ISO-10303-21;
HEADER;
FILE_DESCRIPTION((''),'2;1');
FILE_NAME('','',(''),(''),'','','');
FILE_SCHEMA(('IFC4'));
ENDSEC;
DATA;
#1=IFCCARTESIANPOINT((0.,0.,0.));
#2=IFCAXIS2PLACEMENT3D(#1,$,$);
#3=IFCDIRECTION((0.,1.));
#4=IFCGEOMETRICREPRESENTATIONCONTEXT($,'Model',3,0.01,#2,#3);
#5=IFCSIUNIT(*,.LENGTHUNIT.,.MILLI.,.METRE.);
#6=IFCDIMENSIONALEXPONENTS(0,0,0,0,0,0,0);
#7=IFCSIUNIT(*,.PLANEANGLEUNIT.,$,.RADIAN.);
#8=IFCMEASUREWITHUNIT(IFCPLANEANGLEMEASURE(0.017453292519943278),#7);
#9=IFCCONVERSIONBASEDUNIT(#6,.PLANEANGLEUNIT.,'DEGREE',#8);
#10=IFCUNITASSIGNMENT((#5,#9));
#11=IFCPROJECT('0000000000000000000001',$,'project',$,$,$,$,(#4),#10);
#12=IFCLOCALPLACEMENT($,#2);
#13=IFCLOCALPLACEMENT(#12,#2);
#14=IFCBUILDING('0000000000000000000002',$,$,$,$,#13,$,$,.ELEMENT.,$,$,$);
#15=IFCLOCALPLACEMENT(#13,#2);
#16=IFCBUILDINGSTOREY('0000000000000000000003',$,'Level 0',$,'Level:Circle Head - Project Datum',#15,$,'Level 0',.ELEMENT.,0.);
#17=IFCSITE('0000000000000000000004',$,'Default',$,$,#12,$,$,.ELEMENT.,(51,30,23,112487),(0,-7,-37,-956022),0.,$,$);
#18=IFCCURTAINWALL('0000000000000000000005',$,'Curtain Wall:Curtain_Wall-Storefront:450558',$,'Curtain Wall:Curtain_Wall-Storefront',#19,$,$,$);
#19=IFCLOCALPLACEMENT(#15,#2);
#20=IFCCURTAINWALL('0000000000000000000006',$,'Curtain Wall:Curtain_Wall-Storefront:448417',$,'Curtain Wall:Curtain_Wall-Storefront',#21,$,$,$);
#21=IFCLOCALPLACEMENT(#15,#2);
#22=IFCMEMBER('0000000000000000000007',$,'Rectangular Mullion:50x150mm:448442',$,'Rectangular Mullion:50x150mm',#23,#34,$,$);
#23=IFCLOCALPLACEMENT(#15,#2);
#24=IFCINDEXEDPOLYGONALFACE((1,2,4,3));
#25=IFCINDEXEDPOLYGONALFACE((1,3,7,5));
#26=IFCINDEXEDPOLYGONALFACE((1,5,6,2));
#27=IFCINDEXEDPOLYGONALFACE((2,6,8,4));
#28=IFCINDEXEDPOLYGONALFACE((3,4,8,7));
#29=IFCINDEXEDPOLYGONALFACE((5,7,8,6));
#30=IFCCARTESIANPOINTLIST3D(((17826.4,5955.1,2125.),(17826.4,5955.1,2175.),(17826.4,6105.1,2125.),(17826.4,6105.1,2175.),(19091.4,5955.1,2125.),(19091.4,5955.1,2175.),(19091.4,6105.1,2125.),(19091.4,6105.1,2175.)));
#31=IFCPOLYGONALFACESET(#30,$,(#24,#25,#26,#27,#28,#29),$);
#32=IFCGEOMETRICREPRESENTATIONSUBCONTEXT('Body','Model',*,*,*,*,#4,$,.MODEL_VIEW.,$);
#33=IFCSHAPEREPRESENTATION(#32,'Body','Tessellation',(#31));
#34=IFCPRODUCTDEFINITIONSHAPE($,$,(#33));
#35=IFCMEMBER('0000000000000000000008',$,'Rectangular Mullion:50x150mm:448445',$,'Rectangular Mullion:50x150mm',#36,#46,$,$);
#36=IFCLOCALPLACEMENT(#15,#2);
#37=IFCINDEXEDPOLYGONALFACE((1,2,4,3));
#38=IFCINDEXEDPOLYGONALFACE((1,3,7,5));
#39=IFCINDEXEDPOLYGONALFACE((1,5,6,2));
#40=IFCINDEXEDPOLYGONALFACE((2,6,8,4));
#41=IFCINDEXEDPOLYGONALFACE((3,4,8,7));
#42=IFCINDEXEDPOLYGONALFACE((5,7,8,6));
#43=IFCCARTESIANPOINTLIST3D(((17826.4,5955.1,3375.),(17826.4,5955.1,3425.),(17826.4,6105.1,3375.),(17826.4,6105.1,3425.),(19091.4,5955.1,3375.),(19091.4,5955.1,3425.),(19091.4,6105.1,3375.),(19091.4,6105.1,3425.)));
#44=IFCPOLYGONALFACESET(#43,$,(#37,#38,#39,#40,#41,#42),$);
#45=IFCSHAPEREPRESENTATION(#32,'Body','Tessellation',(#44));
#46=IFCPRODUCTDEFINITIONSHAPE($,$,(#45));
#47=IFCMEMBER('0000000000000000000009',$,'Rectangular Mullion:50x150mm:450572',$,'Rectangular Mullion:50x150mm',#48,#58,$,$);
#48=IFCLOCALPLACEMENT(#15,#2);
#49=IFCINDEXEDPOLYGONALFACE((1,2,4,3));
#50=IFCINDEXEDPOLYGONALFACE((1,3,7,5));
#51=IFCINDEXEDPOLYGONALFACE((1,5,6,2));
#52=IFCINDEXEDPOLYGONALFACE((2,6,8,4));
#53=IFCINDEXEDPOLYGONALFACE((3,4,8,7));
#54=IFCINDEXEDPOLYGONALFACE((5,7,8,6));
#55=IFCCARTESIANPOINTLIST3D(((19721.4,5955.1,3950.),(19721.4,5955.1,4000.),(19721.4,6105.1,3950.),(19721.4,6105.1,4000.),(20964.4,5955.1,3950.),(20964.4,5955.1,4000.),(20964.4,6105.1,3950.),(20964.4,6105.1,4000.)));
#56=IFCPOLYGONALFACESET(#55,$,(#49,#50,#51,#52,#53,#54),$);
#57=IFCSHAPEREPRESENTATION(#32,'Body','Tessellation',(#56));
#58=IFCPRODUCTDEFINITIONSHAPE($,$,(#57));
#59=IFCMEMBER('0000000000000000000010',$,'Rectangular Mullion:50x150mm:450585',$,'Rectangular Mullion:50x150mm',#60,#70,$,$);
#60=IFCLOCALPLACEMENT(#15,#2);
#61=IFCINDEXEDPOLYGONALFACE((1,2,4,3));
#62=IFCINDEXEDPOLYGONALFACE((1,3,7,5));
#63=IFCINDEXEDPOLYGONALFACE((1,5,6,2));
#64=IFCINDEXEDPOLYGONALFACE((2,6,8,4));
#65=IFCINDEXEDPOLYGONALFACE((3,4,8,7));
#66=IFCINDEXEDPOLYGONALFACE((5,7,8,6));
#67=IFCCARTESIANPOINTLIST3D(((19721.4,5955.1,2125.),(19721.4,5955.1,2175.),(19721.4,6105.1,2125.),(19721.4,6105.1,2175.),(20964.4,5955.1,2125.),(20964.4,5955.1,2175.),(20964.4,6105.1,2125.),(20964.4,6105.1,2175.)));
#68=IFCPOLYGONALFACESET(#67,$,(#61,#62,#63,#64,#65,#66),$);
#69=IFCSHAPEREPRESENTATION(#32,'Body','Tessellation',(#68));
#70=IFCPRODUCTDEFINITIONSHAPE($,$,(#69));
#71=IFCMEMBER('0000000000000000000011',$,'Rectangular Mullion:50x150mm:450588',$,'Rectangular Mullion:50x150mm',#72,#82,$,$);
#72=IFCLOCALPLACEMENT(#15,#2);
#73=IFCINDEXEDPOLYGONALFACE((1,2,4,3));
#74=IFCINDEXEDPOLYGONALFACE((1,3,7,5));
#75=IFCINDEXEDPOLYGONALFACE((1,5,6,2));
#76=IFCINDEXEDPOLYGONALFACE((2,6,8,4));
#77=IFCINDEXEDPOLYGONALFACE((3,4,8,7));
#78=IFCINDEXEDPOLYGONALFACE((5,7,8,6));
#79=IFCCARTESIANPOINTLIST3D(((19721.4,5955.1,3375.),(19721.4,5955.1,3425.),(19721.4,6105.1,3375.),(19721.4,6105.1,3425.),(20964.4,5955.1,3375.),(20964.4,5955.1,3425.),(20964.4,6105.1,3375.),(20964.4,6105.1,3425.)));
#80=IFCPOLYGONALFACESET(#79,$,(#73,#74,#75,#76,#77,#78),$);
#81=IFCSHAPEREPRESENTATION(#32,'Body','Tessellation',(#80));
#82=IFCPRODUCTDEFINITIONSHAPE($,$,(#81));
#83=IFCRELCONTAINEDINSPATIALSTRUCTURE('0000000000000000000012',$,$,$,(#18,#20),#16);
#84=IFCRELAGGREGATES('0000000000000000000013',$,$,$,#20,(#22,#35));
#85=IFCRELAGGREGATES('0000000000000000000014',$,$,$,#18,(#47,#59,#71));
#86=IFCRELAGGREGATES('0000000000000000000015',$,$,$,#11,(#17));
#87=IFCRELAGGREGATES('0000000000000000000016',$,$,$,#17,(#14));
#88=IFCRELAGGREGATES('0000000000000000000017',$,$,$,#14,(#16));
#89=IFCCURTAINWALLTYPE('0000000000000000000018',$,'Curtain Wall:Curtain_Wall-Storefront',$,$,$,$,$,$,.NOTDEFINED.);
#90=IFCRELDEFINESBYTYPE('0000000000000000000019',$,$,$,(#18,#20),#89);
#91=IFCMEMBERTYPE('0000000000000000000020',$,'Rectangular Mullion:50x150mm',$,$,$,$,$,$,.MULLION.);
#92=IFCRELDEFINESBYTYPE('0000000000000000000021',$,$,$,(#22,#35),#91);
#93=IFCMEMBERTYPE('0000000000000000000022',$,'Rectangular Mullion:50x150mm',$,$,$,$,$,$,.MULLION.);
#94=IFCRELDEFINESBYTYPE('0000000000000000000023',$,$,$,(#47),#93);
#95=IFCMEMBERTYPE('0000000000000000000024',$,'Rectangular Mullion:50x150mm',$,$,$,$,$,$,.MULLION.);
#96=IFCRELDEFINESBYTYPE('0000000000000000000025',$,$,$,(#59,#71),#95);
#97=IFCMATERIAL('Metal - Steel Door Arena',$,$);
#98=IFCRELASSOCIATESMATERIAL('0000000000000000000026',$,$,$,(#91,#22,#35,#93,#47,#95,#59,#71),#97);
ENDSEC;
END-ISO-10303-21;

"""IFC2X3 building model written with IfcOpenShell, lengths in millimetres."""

from ifc_helpers import new_model, entity, si_unit, converted_unit, direction, frame, origin, origin_2d_with_axis, place, context, subcontext, project, spatial, rectangle, extrude, source, transform, mapped, material, type_object, type_shapes, element, aggregate, save


model = new_model("IFC2X3")

# Units and contexts
model_context = context("Model", 3, precision=0.01, world=origin(), true_north=direction((0.0, 1.0)))
body_context = subcontext(model_context, "Body", "Model", "MODEL_VIEW")
ifc_project = project(units=[si_unit("LENGTHUNIT", "METRE", prefix="MILLI"), converted_unit("PLANEANGLEUNIT", "DEGREE", entity("IfcPlaneAngleMeasure", 0.017453292519943278), si_unit("PLANEANGLEUNIT", "RADIAN"), dimensions=[0, 0, 0, 0, 0, 0, 0])], contexts=[model_context])

# Site, building, storey
site_placement = place(None, origin())
site = spatial("IfcSite", under=ifc_project, at=site_placement, Name="Default", CompositionType="ELEMENT", RefLatitude=(51, 30, 23, 112487), RefLongitude=(0, -7, -37, -956022), RefElevation=0.0)
building_placement = place(site_placement, origin())
building = spatial("IfcBuilding", under=site, at=building_placement, CompositionType="ELEMENT")
storey_placement = place(building_placement, origin())
storey = spatial("IfcBuildingStorey", under=building, at=storey_placement, Name="Level 0", ObjectType="Level:Circle Head - Project Datum", LongName="Level 0", CompositionType="ELEMENT", Elevation=0.0)

# Curtain walls, members
curtain_wall_type = type_object("IfcCurtainWallType", Name="Curtain Wall:Curtain_Wall-Storefront", PredefinedType="NOTDEFINED")
curtain_wall_1_placement = place(storey_placement, origin())
curtain_wall_1 = element("IfcCurtainWall", 1, at=curtain_wall_1_placement, inside=storey, type_object=curtain_wall_type, Name="Curtain Wall:Curtain_Wall-Storefront:450558", ObjectType="Curtain Wall:Curtain_Wall-Storefront")
ifc_material_1 = material(Name="Metal - Steel Door Arena")
curtain_wall_2_placement = place(storey_placement, origin())
curtain_wall_2 = element("IfcCurtainWall", 2, at=curtain_wall_2_placement, inside=storey, type_object=curtain_wall_type, Name="Curtain Wall:Curtain_Wall-Storefront:448417", ObjectType="Curtain Wall:Curtain_Wall-Storefront")
member_type_1 = type_object("IfcMemberType", Name="Rectangular Mullion:50x150mm", PredefinedType="MULLION", material=ifc_material_1)
shared_shape_1 = source(origin(), body_context, "Body", "SweptSolid", [
    extrude(rectangle(XDim=50.0, YDim=150.0, at=origin_2d_with_axis()), frame((0.0, 0.0, -1265.0), z_axis=(0.0, 0.0, 1.0), x_axis=(-1.0, 0.0, 0.0)), (0.0, 0.0, 1.0), 1265.0),
])
type_shapes(member_type_1, [shared_shape_1])
member_1_placement = place(curtain_wall_2_placement, frame((17826.4, 6030.1, 2150.0), z_axis=(-1.0, 0.0, 0.0), x_axis=(0.0, 0.0, 1.0)))
member_1 = element("IfcMember", 3, at=member_1_placement, type_object=member_type_1, material=ifc_material_1, Name="Rectangular Mullion:50x150mm:448442", ObjectType="Rectangular Mullion:50x150mm", context=body_context, shape_type="MappedRepresentation", body=[
    mapped(shared_shape_1, transform((0.0, 0.0, 0.0), scale=1.0)),
])
member_2_placement = place(curtain_wall_2_placement, frame((17826.4, 6030.1, 3400.0), z_axis=(-1.0, 0.0, 0.0), x_axis=(0.0, 0.0, 1.0)))
member_2 = element("IfcMember", 4, at=member_2_placement, type_object=member_type_1, material=ifc_material_1, Name="Rectangular Mullion:50x150mm:448445", ObjectType="Rectangular Mullion:50x150mm", context=body_context, shape_type="MappedRepresentation", body=[
    mapped(shared_shape_1, transform((0.0, 0.0, 0.0), scale=1.0)),
])

# Members
member_type_2 = type_object("IfcMemberType", Name="Rectangular Mullion:50x150mm", PredefinedType="MULLION", material=ifc_material_1)
shared_shape_2 = source(origin(), body_context, "Body", "SweptSolid", [
    extrude(rectangle(XDim=50.0, YDim=150.0, at=origin_2d_with_axis()), frame((-25.0, 0.0, -1243.0), z_axis=(0.0, 0.0, 1.0), x_axis=(-1.0, 0.0, 0.0)), (0.0, 0.0, 1.0), 1243.0),
])
type_shapes(member_type_2, [shared_shape_2])
member_3_placement = place(curtain_wall_1_placement, frame((19721.4, 6030.1, 4000.0), z_axis=(-1.0, 0.0, 0.0), x_axis=(0.0, 0.0, 1.0)))
member_3 = element("IfcMember", 5, at=member_3_placement, type_object=member_type_2, material=ifc_material_1, Name="Rectangular Mullion:50x150mm:450572", ObjectType="Rectangular Mullion:50x150mm", context=body_context, shape_type="MappedRepresentation", body=[
    mapped(shared_shape_2, transform((0.0, 0.0, 0.0), scale=1.0)),
])
member_type_3 = type_object("IfcMemberType", Name="Rectangular Mullion:50x150mm", PredefinedType="MULLION", material=ifc_material_1)
shared_shape_3 = source(origin(), body_context, "Body", "SweptSolid", [
    extrude(rectangle(XDim=50.0, YDim=150.0, at=origin_2d_with_axis()), frame((0.0, 0.0, -1243.0), z_axis=(0.0, 0.0, 1.0), x_axis=(-1.0, 0.0, 0.0)), (0.0, 0.0, 1.0), 1243.0),
])
type_shapes(member_type_3, [shared_shape_3])
member_4_placement = place(curtain_wall_1_placement, frame((19721.4, 6030.1, 2150.0), z_axis=(-1.0, 0.0, 0.0), x_axis=(0.0, 0.0, 1.0)))
member_4 = element("IfcMember", 6, at=member_4_placement, type_object=member_type_3, material=ifc_material_1, Name="Rectangular Mullion:50x150mm:450585", ObjectType="Rectangular Mullion:50x150mm", context=body_context, shape_type="MappedRepresentation", body=[
    mapped(shared_shape_3, transform((0.0, 0.0, 0.0), scale=1.0)),
])
member_5_placement = place(curtain_wall_1_placement, frame((19721.4, 6030.1, 3400.0), z_axis=(-1.0, 0.0, 0.0), x_axis=(0.0, 0.0, 1.0)))
member_5 = element("IfcMember", 7, at=member_5_placement, type_object=member_type_3, material=ifc_material_1, Name="Rectangular Mullion:50x150mm:450588", ObjectType="Rectangular Mullion:50x150mm", context=body_context, shape_type="MappedRepresentation", body=[
    mapped(shared_shape_3, transform((0.0, 0.0, 0.0), scale=1.0)),
])

aggregate(curtain_wall_2, [member_1, member_2])
aggregate(curtain_wall_1, [member_3, member_4, member_5])

save(model, "model.ifc")
